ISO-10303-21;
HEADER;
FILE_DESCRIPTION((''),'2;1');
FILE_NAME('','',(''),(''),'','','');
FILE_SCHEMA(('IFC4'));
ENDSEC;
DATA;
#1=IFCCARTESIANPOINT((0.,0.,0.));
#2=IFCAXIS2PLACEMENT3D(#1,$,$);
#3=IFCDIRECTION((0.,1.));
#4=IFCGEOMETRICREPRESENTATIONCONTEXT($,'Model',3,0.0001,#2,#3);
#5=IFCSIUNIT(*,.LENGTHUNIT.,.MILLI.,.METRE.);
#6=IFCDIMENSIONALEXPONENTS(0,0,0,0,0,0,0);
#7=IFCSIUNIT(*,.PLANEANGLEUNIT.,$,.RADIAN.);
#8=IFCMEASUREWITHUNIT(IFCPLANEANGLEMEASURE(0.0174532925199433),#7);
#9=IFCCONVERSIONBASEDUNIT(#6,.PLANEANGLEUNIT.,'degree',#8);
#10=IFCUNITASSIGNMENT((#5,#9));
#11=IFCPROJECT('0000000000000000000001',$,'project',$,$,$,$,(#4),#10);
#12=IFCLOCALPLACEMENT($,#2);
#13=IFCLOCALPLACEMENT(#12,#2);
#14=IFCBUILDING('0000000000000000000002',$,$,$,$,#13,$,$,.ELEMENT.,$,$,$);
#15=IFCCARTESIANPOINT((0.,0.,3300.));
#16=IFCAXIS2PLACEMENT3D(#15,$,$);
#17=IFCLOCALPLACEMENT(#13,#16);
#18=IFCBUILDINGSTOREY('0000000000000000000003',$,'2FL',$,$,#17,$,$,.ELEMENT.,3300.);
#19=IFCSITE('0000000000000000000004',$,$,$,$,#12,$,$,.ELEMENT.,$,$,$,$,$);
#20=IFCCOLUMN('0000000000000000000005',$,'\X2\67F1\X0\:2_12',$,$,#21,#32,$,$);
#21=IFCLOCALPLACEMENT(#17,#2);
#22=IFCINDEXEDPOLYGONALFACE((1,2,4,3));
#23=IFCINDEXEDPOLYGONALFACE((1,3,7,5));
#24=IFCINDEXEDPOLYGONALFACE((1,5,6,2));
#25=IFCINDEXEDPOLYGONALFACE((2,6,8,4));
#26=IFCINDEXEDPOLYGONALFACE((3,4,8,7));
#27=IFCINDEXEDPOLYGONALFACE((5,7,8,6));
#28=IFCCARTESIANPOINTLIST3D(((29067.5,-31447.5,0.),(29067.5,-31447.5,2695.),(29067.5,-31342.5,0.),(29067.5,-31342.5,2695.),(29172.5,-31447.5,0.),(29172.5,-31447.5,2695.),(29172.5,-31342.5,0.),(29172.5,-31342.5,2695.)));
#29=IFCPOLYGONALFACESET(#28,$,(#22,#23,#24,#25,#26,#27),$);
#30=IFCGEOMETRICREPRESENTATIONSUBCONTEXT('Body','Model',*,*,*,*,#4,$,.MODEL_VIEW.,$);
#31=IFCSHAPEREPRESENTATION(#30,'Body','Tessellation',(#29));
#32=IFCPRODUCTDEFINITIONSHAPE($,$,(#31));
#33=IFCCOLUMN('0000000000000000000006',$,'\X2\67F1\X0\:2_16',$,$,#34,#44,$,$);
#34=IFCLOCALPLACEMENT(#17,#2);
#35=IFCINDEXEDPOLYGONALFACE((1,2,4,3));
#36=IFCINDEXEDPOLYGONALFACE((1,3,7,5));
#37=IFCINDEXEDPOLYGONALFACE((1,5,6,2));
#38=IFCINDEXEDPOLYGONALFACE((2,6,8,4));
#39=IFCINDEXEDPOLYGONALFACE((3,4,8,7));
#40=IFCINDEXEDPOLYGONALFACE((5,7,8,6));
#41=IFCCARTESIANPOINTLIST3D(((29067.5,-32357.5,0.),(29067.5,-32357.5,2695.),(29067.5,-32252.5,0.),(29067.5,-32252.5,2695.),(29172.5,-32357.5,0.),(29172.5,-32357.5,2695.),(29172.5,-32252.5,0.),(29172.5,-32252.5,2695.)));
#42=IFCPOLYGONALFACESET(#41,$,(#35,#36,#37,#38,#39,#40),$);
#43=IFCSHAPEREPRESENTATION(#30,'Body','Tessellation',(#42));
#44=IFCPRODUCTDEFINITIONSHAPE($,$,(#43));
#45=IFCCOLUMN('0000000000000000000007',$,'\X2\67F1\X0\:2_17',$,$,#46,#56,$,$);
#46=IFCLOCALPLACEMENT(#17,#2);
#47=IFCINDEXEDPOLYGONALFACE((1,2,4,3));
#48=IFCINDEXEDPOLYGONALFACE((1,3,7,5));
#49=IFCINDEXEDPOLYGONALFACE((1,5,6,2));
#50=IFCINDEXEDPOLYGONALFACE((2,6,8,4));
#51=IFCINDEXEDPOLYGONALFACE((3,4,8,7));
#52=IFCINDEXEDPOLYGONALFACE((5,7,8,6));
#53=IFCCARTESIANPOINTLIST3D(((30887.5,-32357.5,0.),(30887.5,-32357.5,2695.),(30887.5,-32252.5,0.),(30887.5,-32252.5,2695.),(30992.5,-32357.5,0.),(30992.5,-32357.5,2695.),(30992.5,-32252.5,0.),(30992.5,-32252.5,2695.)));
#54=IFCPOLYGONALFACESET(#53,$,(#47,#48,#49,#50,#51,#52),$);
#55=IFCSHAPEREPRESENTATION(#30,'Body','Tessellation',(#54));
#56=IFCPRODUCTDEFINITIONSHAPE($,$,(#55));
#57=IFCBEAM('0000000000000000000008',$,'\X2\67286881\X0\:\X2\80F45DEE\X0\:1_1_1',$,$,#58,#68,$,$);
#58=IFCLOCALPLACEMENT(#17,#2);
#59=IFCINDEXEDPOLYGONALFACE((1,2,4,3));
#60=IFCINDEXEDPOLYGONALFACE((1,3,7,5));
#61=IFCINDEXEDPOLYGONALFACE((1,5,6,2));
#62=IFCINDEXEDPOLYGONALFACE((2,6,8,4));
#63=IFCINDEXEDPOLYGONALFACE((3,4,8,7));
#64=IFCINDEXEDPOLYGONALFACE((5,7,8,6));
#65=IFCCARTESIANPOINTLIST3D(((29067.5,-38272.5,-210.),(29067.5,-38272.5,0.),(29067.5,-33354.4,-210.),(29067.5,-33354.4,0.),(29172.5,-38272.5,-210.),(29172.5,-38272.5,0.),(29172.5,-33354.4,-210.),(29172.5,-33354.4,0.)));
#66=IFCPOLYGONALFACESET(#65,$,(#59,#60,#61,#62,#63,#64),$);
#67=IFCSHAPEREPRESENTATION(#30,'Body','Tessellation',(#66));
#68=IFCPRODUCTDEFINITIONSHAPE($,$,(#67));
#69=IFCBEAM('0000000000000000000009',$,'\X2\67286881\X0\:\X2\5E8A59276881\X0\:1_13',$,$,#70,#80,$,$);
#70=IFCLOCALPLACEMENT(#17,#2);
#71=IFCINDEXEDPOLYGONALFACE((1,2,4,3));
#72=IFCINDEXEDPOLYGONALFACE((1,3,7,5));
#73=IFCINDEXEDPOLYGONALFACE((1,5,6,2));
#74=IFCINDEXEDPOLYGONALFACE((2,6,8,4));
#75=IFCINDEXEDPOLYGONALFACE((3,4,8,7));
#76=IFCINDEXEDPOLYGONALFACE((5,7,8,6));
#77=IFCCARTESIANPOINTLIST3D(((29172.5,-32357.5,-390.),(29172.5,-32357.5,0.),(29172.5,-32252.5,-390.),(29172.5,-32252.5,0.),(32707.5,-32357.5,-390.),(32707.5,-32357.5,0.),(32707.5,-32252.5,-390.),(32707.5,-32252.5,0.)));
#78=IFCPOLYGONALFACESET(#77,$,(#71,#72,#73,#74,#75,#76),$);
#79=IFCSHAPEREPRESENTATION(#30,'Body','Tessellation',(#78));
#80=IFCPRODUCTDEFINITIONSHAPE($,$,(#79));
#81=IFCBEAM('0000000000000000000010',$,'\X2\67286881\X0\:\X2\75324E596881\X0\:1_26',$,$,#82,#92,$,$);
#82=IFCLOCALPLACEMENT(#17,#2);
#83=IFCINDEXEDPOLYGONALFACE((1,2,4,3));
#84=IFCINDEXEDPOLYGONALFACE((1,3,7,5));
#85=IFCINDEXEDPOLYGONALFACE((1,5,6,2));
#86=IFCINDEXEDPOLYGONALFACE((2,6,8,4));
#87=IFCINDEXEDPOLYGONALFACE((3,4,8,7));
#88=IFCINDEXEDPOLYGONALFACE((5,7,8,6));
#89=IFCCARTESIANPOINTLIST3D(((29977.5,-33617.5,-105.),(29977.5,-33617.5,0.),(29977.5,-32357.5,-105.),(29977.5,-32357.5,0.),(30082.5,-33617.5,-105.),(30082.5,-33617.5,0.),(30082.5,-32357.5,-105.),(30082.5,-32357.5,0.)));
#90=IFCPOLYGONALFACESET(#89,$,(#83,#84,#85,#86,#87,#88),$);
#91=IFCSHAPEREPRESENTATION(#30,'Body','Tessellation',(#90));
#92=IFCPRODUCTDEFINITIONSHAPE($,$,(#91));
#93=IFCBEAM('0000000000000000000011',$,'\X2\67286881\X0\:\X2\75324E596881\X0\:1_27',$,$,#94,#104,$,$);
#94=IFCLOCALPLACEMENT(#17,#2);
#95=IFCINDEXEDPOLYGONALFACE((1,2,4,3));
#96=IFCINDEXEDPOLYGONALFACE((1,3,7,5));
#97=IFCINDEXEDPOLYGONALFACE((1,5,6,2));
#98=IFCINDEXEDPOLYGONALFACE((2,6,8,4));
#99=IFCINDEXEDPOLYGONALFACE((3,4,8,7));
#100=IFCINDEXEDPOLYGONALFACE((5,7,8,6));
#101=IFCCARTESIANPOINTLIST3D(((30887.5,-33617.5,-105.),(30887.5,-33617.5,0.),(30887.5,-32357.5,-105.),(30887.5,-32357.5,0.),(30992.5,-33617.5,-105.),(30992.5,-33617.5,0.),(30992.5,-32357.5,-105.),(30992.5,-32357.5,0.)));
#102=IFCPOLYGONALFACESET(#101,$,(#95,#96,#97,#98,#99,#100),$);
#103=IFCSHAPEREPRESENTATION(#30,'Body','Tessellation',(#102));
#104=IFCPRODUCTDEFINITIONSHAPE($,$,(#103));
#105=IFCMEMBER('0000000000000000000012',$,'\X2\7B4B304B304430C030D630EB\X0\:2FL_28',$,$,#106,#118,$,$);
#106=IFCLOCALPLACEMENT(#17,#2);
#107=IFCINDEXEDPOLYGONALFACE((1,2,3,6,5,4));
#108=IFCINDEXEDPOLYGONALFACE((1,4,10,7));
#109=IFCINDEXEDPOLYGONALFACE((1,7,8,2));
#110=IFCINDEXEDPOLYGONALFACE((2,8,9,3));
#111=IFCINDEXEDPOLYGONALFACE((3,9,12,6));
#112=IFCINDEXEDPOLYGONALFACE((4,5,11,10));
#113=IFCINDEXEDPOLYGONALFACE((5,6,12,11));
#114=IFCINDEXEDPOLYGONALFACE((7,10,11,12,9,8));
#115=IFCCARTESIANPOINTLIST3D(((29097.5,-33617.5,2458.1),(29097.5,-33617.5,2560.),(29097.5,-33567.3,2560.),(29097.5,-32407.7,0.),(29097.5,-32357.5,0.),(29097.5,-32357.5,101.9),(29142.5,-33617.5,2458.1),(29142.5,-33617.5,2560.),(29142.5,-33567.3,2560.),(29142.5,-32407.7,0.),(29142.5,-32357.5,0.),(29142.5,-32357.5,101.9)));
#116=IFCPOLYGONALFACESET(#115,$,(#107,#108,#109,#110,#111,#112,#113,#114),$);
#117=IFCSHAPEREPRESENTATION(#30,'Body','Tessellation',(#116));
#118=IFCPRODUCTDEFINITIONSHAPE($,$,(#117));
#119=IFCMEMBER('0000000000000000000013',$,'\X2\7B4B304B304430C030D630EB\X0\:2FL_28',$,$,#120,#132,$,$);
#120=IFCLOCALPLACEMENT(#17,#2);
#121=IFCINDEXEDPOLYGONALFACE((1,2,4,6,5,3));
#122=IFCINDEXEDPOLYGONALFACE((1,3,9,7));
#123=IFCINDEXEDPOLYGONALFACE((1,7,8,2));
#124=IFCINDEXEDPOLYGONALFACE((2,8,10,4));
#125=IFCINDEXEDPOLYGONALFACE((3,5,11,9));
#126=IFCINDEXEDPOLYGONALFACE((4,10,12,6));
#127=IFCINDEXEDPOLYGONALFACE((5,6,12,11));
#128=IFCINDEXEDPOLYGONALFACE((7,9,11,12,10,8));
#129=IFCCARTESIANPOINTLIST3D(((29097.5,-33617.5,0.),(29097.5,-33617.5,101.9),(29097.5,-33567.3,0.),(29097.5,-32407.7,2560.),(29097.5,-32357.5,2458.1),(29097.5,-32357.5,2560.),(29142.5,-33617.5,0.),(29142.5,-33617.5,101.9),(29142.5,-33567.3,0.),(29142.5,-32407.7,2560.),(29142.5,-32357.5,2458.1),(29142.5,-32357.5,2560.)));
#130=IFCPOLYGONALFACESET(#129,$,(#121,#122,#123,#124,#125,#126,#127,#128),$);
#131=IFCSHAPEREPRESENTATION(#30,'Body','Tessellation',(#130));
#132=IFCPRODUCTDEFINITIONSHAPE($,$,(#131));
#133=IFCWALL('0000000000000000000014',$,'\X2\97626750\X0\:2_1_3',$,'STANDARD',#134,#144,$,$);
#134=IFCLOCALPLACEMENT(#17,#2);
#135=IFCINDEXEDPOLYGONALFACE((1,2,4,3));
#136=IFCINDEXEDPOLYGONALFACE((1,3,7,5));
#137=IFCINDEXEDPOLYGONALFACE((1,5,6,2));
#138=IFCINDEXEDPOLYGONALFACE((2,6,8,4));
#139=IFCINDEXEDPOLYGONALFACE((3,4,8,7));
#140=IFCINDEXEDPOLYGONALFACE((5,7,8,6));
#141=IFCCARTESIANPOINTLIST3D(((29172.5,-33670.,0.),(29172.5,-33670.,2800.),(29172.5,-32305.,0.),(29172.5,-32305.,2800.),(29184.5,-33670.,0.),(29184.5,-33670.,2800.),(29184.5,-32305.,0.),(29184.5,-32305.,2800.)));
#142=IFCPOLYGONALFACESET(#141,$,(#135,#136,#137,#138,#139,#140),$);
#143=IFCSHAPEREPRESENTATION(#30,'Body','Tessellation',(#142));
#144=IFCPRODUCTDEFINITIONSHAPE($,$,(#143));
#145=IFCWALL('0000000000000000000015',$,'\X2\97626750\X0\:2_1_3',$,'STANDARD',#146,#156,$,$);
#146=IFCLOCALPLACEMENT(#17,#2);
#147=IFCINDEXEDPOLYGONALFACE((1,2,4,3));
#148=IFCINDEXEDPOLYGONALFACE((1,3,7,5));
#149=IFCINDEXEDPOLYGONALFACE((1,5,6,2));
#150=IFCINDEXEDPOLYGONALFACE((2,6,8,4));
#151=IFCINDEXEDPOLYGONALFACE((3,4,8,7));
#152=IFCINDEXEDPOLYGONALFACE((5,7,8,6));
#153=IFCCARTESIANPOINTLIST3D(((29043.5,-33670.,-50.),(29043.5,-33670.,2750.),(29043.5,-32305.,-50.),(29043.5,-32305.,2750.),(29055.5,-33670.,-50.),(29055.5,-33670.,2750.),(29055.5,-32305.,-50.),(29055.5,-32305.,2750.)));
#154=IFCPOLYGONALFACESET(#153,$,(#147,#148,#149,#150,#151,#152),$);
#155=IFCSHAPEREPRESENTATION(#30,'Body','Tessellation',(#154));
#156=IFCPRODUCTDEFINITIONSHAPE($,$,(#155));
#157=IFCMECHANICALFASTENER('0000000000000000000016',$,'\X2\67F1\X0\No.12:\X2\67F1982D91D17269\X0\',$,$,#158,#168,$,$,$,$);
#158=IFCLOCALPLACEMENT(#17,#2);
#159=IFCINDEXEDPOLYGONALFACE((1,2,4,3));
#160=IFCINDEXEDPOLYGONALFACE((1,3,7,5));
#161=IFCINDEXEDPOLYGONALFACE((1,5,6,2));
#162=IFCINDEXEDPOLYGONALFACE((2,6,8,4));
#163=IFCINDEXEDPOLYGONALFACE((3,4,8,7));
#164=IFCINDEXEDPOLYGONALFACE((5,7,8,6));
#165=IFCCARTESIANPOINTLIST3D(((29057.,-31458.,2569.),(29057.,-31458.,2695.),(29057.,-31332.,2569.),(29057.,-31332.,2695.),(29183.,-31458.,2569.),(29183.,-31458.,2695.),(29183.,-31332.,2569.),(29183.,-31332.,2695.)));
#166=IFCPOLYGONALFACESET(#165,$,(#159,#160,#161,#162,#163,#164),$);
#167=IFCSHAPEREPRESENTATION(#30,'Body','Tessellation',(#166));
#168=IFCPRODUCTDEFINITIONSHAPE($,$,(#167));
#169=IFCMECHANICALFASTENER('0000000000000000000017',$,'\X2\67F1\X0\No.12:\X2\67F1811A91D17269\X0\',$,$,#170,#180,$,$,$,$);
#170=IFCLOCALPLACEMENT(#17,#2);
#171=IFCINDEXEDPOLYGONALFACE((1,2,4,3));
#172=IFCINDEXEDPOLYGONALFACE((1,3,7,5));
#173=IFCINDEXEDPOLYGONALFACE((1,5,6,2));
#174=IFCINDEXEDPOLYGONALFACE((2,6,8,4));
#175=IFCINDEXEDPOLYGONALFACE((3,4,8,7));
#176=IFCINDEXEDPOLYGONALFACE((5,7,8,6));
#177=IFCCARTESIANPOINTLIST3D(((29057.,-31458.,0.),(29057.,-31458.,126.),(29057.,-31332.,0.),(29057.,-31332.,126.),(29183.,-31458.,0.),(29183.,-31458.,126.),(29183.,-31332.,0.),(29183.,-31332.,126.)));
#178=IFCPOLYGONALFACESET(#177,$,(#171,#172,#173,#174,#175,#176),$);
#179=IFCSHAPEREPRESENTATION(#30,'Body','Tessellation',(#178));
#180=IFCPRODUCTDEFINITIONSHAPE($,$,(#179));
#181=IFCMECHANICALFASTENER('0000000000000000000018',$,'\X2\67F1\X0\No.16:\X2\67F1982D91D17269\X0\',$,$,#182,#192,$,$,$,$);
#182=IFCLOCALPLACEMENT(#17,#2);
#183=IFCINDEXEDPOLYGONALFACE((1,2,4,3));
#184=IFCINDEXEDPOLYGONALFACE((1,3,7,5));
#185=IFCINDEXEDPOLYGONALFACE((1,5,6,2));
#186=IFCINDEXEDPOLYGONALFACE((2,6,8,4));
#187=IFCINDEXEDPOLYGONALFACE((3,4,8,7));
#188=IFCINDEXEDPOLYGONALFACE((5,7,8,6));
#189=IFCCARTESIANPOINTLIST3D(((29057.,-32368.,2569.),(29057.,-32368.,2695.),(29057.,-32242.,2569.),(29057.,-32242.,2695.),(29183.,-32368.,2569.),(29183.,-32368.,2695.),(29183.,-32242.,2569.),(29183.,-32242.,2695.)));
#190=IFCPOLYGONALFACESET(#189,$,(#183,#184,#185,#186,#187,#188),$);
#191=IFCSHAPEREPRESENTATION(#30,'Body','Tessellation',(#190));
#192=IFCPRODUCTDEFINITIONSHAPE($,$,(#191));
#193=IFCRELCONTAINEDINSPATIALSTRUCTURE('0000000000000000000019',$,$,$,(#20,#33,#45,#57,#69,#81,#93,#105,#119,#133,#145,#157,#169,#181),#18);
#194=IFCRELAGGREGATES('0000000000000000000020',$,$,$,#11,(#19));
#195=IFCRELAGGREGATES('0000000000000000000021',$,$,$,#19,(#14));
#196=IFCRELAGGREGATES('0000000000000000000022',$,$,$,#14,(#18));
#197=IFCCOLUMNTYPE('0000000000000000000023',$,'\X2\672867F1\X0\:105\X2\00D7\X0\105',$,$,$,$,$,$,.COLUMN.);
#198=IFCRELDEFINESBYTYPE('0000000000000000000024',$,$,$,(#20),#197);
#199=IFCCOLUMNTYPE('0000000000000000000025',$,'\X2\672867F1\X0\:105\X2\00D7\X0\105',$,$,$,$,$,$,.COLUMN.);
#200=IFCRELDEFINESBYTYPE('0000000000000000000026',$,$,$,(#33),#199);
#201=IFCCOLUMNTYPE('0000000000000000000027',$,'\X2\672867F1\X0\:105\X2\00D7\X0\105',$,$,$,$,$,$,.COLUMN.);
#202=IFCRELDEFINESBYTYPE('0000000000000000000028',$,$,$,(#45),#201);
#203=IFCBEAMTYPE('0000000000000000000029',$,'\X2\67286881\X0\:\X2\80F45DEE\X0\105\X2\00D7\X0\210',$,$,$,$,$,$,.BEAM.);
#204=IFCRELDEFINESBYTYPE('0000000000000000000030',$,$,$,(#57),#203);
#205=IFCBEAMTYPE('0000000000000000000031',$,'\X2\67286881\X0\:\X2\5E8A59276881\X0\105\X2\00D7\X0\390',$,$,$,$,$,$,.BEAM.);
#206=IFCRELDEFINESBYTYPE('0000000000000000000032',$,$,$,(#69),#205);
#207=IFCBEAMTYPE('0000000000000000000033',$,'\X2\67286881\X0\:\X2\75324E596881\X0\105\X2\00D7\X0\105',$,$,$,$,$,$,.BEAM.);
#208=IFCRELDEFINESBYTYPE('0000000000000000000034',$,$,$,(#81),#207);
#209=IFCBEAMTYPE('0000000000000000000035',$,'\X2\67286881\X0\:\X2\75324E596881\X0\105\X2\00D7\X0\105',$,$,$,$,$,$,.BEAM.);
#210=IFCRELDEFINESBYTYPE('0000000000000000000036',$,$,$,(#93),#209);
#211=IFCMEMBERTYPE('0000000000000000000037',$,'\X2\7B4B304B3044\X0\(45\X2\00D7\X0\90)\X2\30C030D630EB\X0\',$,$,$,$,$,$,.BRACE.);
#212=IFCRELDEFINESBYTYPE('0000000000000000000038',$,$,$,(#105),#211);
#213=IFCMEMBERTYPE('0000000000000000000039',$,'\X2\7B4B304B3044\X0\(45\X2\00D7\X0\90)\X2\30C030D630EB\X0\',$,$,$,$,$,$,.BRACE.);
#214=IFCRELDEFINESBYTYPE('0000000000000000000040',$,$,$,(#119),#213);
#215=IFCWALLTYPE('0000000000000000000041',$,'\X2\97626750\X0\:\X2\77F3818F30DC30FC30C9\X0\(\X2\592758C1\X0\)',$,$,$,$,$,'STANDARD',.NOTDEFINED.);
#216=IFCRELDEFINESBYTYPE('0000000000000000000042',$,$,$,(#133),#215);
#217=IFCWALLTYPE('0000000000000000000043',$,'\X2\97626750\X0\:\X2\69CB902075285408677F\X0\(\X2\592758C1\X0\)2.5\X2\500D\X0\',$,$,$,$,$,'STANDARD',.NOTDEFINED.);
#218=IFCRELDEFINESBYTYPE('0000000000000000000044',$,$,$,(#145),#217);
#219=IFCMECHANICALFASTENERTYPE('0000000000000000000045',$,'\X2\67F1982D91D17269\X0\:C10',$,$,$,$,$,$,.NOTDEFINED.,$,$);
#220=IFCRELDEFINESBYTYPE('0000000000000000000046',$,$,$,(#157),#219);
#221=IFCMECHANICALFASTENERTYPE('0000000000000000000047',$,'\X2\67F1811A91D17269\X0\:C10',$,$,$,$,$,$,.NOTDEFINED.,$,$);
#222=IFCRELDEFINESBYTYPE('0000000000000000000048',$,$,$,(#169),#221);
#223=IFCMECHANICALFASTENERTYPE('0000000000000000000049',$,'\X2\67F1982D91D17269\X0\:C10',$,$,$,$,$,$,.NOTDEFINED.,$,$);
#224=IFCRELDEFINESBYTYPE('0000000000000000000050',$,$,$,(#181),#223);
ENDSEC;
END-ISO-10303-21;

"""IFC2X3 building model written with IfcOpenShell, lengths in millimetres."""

from ifc_helpers import new_model, entity, si_unit, converted_unit, direction, frame, origin, origin_with_axes, origin_2d, place, context, subcontext, project, spatial, polyline, rectangle, outline, extrude, type_object, element, save


model = new_model("IFC2X3")

# Units and contexts
model_context = context("Model", 3, precision=0.0001, world=origin(), true_north=direction((0.0, 1.0)))
body_context = subcontext(model_context, "Body", "Model", "MODEL_VIEW")
ifc_project = project(units=[si_unit("LENGTHUNIT", "METRE", prefix="MILLI"), converted_unit("PLANEANGLEUNIT", "degree", entity("IfcPlaneAngleMeasure", 0.0174532925199433), si_unit("PLANEANGLEUNIT", "RADIAN"), dimensions=[0, 0, 0, 0, 0, 0, 0])], contexts=[model_context])

# Site, building, storey
site_placement = place(None, origin())
site = spatial("IfcSite", under=ifc_project, at=site_placement, CompositionType="ELEMENT")
building_placement = place(site_placement, origin())
building = spatial("IfcBuilding", under=site, at=building_placement, CompositionType="ELEMENT")
storey_placement = place(building_placement, frame((0.0, 0.0, 3300.0)))
storey = spatial("IfcBuildingStorey", under=building, at=storey_placement, Name="2FL", CompositionType="ELEMENT", Elevation=3300.0)

# Columns
column_type_1 = type_object("IfcColumnType", Name="木柱:105×105", PredefinedType="COLUMN")
column_1_placement = place(storey_placement, frame((29120.0, -31395.0, 0.0)))
element("IfcColumn", 1, at=column_1_placement, inside=storey, type_object=column_type_1, Name="柱:2_12", context=body_context, shape_type="SweptSolid", body=[
    extrude(rectangle(XDim=105.0, YDim=105.0, at=origin_2d()), origin_with_axes(), (0.0, 0.0, 1.0), 2695.0),
])
column_type_2 = type_object("IfcColumnType", Name="木柱:105×105", PredefinedType="COLUMN")
column_2_placement = place(storey_placement, frame((29120.0, -32305.0, 0.0)))
element("IfcColumn", 2, at=column_2_placement, inside=storey, type_object=column_type_2, Name="柱:2_16", context=body_context, shape_type="SweptSolid", body=[
    extrude(rectangle(XDim=105.0, YDim=105.0, at=origin_2d()), origin_with_axes(), (0.0, 0.0, 1.0), 2695.0),
])
column_type_3 = type_object("IfcColumnType", Name="木柱:105×105", PredefinedType="COLUMN")
column_3_placement = place(storey_placement, frame((30940.0, -32305.0, 0.0)))
element("IfcColumn", 3, at=column_3_placement, inside=storey, type_object=column_type_3, Name="柱:2_17", context=body_context, shape_type="SweptSolid", body=[
    extrude(rectangle(XDim=105.0, YDim=105.0, at=origin_2d()), origin_with_axes(), (0.0, 0.0, 1.0), 2695.0),
])

# Beams
beam_type_1 = type_object("IfcBeamType", Name="木梁:胴差105×210", PredefinedType="BEAM")
beam_1_placement = place(storey_placement, frame((29120.0, -33354.4, -105.0), z_axis=(0.0, -1.0, 0.0), x_axis=(1.0, 0.0, 0.0)))
element("IfcBeam", 4, at=beam_1_placement, inside=storey, type_object=beam_type_1, Name="木梁:胴差:1_1_1", context=body_context, shape_type="SweptSolid", body=[
    extrude(rectangle(XDim=105.0, YDim=210.0, at=origin_2d()), origin_with_axes(), (0.0, 0.0, 1.0), 4918.1),
])
beam_type_2 = type_object("IfcBeamType", Name="木梁:床大梁105×390", PredefinedType="BEAM")
beam_2_placement = place(storey_placement, frame((29172.5, -32305.0, -195.0), z_axis=(1.0, 0.0, 0.0), x_axis=(0.0, 1.0, 0.0)))
element("IfcBeam", 5, at=beam_2_placement, inside=storey, type_object=beam_type_2, Name="木梁:床大梁:1_13", context=body_context, shape_type="SweptSolid", body=[
    extrude(rectangle(XDim=105.0, YDim=390.0, at=origin_2d()), origin_with_axes(), (0.0, 0.0, 1.0), 3535.0),
])
beam_type_3 = type_object("IfcBeamType", Name="木梁:甲乙梁105×105", PredefinedType="BEAM")
beam_3_placement = place(storey_placement, frame((30030.0, -32357.5, -52.5), z_axis=(0.0, -1.0, 0.0), x_axis=(1.0, 0.0, 0.0)))
element("IfcBeam", 6, at=beam_3_placement, inside=storey, type_object=beam_type_3, Name="木梁:甲乙梁:1_26", context=body_context, shape_type="SweptSolid", body=[
    extrude(rectangle(XDim=105.0, YDim=105.0, at=origin_2d()), origin_with_axes(), (0.0, 0.0, 1.0), 1260.0),
])
beam_type_4 = type_object("IfcBeamType", Name="木梁:甲乙梁105×105", PredefinedType="BEAM")
beam_4_placement = place(storey_placement, frame((30940.0, -32357.5, -52.5), z_axis=(0.0, -1.0, 0.0), x_axis=(1.0, 0.0, 0.0)))
element("IfcBeam", 7, at=beam_4_placement, inside=storey, type_object=beam_type_4, Name="木梁:甲乙梁:1_27", context=body_context, shape_type="SweptSolid", body=[
    extrude(rectangle(XDim=105.0, YDim=105.0, at=origin_2d()), origin_with_axes(), (0.0, 0.0, 1.0), 1260.0),
])

# Members
member_type_1 = type_object("IfcMemberType", Name="筋かい(45×90)ダブル", PredefinedType="BRACE")
member_1_placement = place(storey_placement, frame((29120.0, -32357.5, 0.0), z_axis=(0.0, -0.441597, 0.897213), x_axis=(0.0, 0.897213, 0.441597)))
element("IfcMember", 8, at=member_1_placement, inside=storey, type_object=member_type_1, Name="筋かいダブル:2FL_28", context=body_context, shape_type="SweptSolid", body=[
    extrude(outline(polyline([(0.0, 0.0), (22.1, -45.0), (2761.9, -45.0), (2853.3, 0.0), (2831.1, 45.0), (91.4, 45.0), (0.0, 0.0)])), frame((0.0, -22.5, 0.0), z_axis=(0.0, 1.0, 0.0), x_axis=(0.0, 0.0, 1.0)), (0.0, 0.0, 1.0), 45.0),
])
member_type_2 = type_object("IfcMemberType", Name="筋かい(45×90)ダブル", PredefinedType="BRACE")
member_2_placement = place(storey_placement, frame((29120.0, -33617.5, 0.0), z_axis=(0.0, 0.441597, 0.897213), x_axis=(0.0, -0.897213, 0.441597)))
element("IfcMember", 9, at=member_2_placement, inside=storey, type_object=member_type_2, Name="筋かいダブル:2FL_28", context=body_context, shape_type="SweptSolid", body=[
    extrude(outline(polyline([(0.0, 0.0), (22.1, -45.0), (2761.9, -45.0), (2853.3, 0.0), (2831.1, 45.0), (91.4, 45.0), (0.0, 0.0)])), frame((0.0, -22.5, 0.0), z_axis=(0.0, 1.0, 0.0), x_axis=(0.0, 0.0, 1.0)), (0.0, 0.0, 1.0), 45.0),
])

# Walls
wall_type_1 = type_object("IfcWallType", Name="面材:石膏ボード(大壁)", ElementType="STANDARD", PredefinedType="NOTDEFINED")
wall_1_placement = place(storey_placement, frame((29184.5, -32987.5, 0.0), z_axis=(-1.0, 0.0, 0.0), x_axis=(0.0, -1.0, 0.0)))
element("IfcWall", 10, at=wall_1_placement, inside=storey, type_object=wall_type_1, Name="面材:2_1_3", ObjectType="STANDARD", context=body_context, shape_type="SweptSolid", body=[
    extrude(outline(polyline([(682.5, 0.0, 0.0), (-682.5, 0.0, 0.0), (-682.5, 2800.0, 0.0), (682.5, 2800.0, 0.0), (682.5, 0.0, 0.0)])), origin_with_axes(), (0.0, 0.0, 1.0), 12.0),
])
wall_type_2 = type_object("IfcWallType", Name="面材:構造用合板(大壁)2.5倍", ElementType="STANDARD", PredefinedType="NOTDEFINED")
wall_2_placement = place(storey_placement, frame((29055.5, -32987.5, -50.0), z_axis=(-1.0, 0.0, 0.0), x_axis=(0.0, -1.0, 0.0)))
element("IfcWall", 11, at=wall_2_placement, inside=storey, type_object=wall_type_2, Name="面材:2_1_3", ObjectType="STANDARD", context=body_context, shape_type="SweptSolid", body=[
    extrude(outline(polyline([(682.5, 0.0, 0.0), (-682.5, 0.0, 0.0), (-682.5, 2800.0, 0.0), (682.5, 2800.0, 0.0), (682.5, 0.0, 0.0)])), origin_with_axes(), (0.0, 0.0, 1.0), 12.0),
])

# Mechanical fasteners
mechanical_fastener_type_1 = type_object("IfcMechanicalFastenerType", Name="柱頭金物:C10")
mechanical_fastener_1_placement = place(storey_placement, frame((29120.0, -31395.0, 2569.0)))
element("IfcMechanicalFastener", 12, at=mechanical_fastener_1_placement, inside=storey, type_object=mechanical_fastener_type_1, Name="柱No.12:柱頭金物", context=body_context, shape_type="SweptSolid", body=[
    extrude(rectangle(XDim=126.0, YDim=126.0, at=origin_2d()), origin_with_axes(), (0.0, 0.0, 1.0), 126.0),
])
mechanical_fastener_type_2 = type_object("IfcMechanicalFastenerType", Name="柱脚金物:C10")
mechanical_fastener_2_placement = place(storey_placement, frame((29120.0, -31395.0, 0.0)))
element("IfcMechanicalFastener", 13, at=mechanical_fastener_2_placement, inside=storey, type_object=mechanical_fastener_type_2, Name="柱No.12:柱脚金物", context=body_context, shape_type="SweptSolid", body=[
    extrude(rectangle(XDim=126.0, YDim=126.0, at=origin_2d()), origin_with_axes(), (0.0, 0.0, 1.0), 126.0),
])
mechanical_fastener_type_3 = type_object("IfcMechanicalFastenerType", Name="柱頭金物:C10")
mechanical_fastener_3_placement = place(storey_placement, frame((29120.0, -32305.0, 2569.0)))
element("IfcMechanicalFastener", 14, at=mechanical_fastener_3_placement, inside=storey, type_object=mechanical_fastener_type_3, Name="柱No.16:柱頭金物", context=body_context, shape_type="SweptSolid", body=[
    extrude(rectangle(XDim=126.0, YDim=126.0, at=origin_2d()), origin_with_axes(), (0.0, 0.0, 1.0), 126.0),
])

save(model, "model.ifc")
